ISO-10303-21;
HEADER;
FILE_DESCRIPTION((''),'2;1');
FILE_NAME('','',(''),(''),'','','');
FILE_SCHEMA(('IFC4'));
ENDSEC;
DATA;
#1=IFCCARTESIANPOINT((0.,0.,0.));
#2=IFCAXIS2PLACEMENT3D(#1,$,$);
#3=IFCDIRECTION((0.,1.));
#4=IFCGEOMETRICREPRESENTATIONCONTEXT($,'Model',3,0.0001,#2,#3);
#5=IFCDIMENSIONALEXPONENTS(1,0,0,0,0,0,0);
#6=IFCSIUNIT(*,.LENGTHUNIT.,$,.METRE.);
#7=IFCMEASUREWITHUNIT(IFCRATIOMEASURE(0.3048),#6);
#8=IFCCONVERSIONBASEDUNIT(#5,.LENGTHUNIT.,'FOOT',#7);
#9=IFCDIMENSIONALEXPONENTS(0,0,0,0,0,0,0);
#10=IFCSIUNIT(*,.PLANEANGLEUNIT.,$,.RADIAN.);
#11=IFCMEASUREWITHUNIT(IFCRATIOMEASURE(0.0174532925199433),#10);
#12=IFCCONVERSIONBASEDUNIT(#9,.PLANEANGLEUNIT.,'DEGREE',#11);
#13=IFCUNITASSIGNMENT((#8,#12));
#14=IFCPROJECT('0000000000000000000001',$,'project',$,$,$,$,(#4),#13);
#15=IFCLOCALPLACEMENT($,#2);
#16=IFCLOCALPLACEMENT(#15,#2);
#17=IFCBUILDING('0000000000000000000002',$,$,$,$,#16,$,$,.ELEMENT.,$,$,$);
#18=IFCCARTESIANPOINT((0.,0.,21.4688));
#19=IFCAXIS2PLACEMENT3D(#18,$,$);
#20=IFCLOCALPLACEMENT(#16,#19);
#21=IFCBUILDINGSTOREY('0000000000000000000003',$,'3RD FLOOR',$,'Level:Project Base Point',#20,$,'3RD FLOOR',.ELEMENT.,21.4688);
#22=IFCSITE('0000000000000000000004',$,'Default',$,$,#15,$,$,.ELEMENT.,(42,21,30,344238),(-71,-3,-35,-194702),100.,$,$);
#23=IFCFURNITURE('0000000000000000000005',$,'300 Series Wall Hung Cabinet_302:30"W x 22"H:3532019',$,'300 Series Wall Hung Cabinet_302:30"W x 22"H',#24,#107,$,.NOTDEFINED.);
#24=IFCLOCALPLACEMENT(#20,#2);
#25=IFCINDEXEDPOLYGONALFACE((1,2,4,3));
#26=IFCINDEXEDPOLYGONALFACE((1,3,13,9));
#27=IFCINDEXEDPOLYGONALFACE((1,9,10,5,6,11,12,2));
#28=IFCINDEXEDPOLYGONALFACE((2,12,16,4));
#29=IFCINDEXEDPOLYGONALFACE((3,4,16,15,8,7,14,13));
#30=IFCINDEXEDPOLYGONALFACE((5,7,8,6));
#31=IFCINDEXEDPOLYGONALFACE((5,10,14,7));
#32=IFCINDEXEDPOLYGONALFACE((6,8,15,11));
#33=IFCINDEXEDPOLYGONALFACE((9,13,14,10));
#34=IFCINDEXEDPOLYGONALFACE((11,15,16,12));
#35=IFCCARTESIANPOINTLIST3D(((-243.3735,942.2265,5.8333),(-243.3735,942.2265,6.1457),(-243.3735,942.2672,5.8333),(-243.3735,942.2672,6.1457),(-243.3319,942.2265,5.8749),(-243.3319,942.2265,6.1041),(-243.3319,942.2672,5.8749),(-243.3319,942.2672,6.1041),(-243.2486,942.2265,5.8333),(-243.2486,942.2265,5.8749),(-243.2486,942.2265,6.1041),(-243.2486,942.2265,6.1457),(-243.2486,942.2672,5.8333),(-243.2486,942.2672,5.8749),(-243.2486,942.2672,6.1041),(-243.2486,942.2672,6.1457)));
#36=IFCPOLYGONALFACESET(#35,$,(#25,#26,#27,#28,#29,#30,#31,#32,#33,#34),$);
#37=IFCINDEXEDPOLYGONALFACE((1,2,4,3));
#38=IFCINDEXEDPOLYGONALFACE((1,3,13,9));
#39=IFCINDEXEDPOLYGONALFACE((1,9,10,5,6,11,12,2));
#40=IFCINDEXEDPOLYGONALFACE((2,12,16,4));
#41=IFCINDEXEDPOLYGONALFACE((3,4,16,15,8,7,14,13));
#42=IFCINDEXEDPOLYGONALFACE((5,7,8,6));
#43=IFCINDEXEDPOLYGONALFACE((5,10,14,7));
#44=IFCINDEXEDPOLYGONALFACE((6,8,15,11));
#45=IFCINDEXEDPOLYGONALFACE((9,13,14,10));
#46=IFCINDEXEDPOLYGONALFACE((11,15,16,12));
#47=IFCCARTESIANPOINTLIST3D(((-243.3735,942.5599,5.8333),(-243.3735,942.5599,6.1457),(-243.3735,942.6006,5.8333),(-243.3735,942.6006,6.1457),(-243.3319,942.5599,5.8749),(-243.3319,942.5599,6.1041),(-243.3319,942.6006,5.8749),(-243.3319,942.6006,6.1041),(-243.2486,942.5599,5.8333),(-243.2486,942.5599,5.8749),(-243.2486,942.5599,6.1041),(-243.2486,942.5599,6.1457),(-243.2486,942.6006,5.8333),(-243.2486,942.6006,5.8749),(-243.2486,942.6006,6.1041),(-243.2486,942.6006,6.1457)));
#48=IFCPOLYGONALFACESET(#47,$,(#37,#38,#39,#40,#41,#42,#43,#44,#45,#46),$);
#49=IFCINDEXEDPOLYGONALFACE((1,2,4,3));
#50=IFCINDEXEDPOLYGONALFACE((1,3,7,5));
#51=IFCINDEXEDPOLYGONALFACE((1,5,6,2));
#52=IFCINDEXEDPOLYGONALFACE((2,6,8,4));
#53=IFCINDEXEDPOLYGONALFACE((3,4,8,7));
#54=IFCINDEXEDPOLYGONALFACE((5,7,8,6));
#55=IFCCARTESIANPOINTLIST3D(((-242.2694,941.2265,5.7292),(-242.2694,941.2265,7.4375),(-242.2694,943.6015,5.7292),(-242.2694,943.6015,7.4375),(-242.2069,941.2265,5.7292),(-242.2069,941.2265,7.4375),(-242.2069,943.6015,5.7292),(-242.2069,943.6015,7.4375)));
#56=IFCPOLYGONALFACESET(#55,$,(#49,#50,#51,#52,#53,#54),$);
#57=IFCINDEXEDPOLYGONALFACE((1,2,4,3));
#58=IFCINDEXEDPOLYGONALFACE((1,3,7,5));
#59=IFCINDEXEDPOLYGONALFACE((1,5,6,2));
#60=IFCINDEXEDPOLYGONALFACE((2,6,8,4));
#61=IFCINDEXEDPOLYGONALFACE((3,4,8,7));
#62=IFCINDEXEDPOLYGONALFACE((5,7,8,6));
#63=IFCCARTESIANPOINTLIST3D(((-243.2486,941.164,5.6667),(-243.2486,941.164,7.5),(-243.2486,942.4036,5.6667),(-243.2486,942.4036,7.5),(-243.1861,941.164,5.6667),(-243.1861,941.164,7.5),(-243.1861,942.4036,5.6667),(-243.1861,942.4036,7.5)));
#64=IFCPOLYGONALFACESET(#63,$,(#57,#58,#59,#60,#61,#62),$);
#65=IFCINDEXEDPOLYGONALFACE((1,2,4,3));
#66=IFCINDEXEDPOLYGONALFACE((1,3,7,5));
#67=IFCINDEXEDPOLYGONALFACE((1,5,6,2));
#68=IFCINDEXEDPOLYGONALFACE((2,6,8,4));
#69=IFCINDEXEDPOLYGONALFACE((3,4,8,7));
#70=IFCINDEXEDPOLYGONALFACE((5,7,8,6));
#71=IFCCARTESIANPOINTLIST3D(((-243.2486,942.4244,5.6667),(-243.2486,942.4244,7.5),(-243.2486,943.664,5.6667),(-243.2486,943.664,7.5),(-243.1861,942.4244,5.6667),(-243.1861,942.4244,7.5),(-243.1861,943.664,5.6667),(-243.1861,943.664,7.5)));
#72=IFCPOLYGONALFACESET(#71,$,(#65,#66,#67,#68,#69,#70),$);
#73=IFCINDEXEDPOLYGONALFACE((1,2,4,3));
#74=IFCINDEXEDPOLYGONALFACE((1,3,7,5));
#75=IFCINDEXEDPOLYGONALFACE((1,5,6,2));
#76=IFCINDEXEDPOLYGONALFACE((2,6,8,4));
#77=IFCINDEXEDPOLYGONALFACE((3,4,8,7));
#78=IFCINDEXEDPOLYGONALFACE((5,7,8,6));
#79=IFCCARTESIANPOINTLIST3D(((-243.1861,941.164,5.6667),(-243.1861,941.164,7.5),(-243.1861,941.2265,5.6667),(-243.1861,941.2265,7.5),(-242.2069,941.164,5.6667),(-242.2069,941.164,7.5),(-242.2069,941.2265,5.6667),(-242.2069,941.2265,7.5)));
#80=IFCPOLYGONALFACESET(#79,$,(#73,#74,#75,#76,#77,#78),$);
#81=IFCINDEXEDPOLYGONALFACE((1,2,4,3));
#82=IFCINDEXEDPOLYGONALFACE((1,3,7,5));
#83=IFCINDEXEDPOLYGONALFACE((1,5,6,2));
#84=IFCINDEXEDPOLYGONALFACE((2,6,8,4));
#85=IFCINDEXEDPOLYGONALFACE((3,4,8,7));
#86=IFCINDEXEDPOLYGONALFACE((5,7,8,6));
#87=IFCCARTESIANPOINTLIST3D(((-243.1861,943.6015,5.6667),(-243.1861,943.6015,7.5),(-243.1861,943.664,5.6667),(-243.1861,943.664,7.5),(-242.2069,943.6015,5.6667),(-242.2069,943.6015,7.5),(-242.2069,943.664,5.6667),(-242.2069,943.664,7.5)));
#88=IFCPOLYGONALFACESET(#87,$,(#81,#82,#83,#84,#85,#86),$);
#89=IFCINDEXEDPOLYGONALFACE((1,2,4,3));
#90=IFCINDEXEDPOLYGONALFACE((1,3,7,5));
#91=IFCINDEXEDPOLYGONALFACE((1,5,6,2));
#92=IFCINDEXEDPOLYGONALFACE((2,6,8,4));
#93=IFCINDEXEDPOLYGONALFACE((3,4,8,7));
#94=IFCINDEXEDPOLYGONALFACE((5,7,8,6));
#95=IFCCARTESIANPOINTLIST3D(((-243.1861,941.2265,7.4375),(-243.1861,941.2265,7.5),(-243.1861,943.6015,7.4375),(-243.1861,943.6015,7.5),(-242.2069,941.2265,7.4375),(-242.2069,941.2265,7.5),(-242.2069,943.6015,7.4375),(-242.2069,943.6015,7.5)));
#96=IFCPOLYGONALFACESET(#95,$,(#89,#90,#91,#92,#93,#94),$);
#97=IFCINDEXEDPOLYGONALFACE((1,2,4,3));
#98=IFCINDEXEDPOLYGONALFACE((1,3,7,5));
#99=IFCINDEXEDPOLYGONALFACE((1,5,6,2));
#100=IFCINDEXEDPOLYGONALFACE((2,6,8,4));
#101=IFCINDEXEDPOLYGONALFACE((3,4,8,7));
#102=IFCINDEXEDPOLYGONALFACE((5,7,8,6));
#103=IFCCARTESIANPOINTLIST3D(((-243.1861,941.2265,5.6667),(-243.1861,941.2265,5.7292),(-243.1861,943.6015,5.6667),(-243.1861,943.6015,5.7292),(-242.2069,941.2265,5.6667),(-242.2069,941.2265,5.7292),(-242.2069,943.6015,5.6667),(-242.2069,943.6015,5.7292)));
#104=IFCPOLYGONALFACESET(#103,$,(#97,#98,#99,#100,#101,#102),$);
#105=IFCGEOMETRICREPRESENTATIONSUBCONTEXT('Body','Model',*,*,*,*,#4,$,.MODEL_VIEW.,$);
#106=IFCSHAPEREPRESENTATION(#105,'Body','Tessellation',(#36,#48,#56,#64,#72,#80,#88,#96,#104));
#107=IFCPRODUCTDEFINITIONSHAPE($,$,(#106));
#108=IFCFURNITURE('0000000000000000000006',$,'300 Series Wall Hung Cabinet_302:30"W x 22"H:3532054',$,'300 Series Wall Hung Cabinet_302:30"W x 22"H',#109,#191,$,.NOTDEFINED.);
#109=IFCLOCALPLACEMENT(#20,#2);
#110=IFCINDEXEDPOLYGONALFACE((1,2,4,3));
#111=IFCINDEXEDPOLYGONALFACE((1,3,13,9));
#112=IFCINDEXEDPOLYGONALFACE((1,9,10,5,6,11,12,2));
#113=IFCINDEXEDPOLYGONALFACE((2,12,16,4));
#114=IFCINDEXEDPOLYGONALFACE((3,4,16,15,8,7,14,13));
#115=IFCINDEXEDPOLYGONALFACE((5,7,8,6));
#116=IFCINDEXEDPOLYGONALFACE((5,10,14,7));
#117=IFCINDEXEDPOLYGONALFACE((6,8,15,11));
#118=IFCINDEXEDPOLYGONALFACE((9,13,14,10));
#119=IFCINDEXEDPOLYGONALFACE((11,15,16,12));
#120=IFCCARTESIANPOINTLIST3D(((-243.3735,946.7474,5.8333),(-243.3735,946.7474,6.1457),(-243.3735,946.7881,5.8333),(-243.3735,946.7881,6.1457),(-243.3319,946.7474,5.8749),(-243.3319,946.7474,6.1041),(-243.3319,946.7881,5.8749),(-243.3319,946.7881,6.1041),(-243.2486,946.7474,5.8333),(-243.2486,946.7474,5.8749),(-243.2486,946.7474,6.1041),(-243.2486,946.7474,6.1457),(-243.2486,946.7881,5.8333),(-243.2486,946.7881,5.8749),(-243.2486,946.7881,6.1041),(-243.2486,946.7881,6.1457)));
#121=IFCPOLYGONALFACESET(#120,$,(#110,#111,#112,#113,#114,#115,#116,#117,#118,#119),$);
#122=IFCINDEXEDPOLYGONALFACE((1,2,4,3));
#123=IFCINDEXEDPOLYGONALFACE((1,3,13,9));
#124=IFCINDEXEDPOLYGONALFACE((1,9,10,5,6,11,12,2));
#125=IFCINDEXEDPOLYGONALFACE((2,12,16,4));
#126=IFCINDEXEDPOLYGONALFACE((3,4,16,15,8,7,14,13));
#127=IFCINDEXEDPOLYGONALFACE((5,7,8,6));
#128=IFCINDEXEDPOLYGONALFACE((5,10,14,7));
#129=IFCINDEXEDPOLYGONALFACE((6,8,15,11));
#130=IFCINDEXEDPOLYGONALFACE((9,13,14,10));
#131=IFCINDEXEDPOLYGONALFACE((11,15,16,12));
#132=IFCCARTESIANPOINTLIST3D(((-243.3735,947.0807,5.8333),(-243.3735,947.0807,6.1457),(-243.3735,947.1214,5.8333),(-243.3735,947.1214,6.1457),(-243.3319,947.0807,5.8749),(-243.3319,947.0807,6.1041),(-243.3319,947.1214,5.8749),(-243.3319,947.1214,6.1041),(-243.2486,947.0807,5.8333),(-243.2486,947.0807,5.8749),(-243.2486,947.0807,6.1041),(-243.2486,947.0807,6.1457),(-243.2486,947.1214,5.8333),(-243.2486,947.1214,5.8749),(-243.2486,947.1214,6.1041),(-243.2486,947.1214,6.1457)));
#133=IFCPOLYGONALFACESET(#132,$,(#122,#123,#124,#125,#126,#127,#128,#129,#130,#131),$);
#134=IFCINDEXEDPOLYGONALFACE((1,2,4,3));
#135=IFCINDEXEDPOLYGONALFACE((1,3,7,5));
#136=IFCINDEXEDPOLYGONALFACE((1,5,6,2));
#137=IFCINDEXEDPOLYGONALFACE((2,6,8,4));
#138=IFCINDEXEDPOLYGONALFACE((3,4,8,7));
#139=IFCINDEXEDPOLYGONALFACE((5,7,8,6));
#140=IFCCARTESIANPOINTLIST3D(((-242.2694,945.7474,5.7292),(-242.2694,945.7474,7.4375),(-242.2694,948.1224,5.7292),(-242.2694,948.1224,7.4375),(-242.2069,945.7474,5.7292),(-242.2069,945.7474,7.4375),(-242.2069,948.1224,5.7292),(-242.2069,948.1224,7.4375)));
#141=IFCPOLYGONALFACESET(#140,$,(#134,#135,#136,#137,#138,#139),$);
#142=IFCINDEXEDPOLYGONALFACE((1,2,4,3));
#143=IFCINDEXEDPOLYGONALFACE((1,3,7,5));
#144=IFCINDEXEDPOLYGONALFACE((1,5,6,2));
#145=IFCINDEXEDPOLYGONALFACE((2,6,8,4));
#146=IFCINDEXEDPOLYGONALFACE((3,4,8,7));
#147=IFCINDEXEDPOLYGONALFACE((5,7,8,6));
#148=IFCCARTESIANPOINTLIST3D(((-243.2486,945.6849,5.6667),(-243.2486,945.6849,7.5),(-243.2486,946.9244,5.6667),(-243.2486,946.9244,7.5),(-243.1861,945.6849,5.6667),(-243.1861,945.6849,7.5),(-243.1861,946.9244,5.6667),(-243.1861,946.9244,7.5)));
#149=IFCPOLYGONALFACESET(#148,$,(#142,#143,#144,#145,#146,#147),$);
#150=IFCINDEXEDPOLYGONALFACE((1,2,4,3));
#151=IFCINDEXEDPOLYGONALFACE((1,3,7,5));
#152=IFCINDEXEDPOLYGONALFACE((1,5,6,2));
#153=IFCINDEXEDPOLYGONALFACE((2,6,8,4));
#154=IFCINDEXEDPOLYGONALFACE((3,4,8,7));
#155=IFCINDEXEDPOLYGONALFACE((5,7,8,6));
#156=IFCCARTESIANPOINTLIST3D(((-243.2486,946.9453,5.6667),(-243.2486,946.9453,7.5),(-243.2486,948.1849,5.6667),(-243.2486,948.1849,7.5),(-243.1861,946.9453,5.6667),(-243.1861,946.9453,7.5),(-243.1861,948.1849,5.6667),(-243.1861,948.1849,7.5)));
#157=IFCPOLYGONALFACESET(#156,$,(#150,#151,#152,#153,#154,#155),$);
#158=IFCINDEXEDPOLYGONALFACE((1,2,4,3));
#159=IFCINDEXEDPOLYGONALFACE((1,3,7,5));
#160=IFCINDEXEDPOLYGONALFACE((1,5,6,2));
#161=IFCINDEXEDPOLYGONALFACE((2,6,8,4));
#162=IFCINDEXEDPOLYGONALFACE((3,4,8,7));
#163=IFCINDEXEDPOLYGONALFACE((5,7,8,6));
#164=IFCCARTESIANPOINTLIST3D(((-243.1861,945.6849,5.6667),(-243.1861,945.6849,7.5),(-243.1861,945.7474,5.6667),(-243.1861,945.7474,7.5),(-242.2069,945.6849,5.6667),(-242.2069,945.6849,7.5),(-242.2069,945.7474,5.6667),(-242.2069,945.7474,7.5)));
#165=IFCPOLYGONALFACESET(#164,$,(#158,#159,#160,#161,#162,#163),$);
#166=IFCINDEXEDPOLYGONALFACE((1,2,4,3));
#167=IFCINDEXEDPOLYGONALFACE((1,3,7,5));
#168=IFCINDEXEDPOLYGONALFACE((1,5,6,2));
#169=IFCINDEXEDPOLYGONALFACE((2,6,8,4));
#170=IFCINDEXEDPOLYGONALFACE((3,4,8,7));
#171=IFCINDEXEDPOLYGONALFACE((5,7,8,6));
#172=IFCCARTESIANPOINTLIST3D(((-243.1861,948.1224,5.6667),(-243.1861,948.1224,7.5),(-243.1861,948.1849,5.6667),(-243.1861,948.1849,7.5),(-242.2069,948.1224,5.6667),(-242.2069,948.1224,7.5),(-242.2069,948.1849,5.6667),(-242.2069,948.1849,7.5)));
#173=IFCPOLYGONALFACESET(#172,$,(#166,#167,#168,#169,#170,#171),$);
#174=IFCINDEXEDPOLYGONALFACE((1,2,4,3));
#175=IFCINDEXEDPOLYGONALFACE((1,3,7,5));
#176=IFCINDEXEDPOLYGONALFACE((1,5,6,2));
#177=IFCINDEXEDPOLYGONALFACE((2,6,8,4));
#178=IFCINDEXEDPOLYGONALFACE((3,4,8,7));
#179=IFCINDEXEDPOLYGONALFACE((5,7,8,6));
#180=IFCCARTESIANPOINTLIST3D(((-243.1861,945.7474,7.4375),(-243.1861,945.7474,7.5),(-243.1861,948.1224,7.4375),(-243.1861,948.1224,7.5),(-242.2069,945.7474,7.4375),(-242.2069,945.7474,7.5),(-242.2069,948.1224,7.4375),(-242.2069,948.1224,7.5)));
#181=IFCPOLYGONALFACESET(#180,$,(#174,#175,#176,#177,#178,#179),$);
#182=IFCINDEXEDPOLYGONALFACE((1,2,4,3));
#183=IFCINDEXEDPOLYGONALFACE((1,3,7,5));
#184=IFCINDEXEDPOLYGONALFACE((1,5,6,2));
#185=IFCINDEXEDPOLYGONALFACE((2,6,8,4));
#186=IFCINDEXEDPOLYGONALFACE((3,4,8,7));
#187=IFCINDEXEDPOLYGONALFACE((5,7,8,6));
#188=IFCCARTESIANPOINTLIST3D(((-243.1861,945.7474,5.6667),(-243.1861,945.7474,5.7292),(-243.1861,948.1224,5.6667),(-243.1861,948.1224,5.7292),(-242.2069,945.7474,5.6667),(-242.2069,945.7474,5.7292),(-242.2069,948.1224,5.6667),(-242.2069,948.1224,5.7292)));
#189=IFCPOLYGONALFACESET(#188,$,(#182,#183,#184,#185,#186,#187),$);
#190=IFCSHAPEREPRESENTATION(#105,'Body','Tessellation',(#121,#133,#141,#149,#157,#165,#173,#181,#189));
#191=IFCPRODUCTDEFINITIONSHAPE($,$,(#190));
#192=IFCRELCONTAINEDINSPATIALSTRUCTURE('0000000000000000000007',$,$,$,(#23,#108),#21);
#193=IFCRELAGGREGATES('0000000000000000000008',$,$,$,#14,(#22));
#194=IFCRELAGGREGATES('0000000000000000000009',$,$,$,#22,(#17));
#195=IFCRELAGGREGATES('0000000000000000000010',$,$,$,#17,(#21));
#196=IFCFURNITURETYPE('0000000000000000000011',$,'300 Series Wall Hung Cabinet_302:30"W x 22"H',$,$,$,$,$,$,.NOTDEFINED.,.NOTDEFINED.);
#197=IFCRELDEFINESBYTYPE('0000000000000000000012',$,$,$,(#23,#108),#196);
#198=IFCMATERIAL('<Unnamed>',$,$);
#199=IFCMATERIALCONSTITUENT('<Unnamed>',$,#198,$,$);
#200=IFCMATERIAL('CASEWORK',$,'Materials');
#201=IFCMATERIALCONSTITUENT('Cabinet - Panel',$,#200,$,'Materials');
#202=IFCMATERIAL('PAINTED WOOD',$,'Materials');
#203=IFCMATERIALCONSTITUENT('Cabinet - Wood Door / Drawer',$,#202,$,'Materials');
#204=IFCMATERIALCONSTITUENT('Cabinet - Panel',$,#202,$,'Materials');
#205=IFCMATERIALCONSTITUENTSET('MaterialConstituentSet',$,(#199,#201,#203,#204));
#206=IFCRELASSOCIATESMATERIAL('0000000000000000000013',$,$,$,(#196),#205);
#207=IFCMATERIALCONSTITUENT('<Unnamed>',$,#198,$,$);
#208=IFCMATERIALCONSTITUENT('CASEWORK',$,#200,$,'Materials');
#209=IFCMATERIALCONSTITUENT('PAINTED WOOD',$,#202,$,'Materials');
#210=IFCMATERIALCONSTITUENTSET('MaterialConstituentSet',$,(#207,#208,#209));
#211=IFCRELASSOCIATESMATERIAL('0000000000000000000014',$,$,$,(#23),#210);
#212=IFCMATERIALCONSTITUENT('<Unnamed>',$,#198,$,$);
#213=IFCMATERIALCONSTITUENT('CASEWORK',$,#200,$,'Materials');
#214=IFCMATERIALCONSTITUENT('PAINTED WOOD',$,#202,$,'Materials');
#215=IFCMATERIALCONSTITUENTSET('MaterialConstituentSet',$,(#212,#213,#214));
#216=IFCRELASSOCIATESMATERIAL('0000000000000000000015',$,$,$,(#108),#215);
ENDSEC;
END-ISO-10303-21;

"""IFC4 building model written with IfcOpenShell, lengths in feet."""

from ifc_helpers import new_model, entity, si_unit, converted_unit, direction, frame, frame_2d, origin, origin_2d_with_axis, place, context, subcontext, project, spatial, polyline, rectangle, outline, extrude, source, transform, mapped, material, constituent, constituent_set, type_object, type_shapes, element, save


model = new_model("IFC4")

# Units and contexts
model_context = context("Model", 3, precision=0.0001, world=origin(), true_north=direction((0.0, 1.0)))
body_context = subcontext(model_context, "Body", "Model", "MODEL_VIEW")
ifc_project = project(units=[converted_unit("LENGTHUNIT", "FOOT", entity("IfcRatioMeasure", 0.3048), si_unit("LENGTHUNIT", "METRE"), dimensions=[1, 0, 0, 0, 0, 0, 0]), converted_unit("PLANEANGLEUNIT", "DEGREE", entity("IfcRatioMeasure", 0.0174532925199433), si_unit("PLANEANGLEUNIT", "RADIAN"), dimensions=[0, 0, 0, 0, 0, 0, 0])], contexts=[model_context])

# Site, building, storey
site_placement = place(None, origin())
site = spatial("IfcSite", under=ifc_project, at=site_placement, Name="Default", CompositionType="ELEMENT", RefLatitude=(42, 21, 30, 344238), RefLongitude=(-71, -3, -35, -194702), RefElevation=100.0)
building_placement = place(site_placement, origin())
building = spatial("IfcBuilding", under=site, at=building_placement, CompositionType="ELEMENT")
storey_placement = place(building_placement, frame((0.0, 0.0, 21.4688)))
storey = spatial("IfcBuildingStorey", under=building, at=storey_placement, Name="3RD FLOOR", ObjectType="Level:Project Base Point", LongName="3RD FLOOR", CompositionType="ELEMENT", Elevation=21.4688)

# Furniture
ifc_material_1 = material(Name="CASEWORK", Category="Materials")
ifc_material_2 = material(Name="<Unnamed>")
ifc_constituent_1 = constituent(ifc_material_2, Name="<Unnamed>")
ifc_constituent_2 = constituent(ifc_material_1, Name="CASEWORK", Category="Materials")
ifc_material_3 = material(Name="PAINTED WOOD", Category="Materials")
ifc_constituent_3 = constituent(ifc_material_3, Name="PAINTED WOOD", Category="Materials")
ifc_constituent_set_1 = constituent_set(constituents=[ifc_constituent_1, ifc_constituent_2, ifc_constituent_3], Name="MaterialConstituentSet")
ifc_constituent_4 = constituent(ifc_material_2, Name="<Unnamed>")
ifc_constituent_5 = constituent(ifc_material_1, Name="Cabinet - Panel", Category="Materials")
ifc_constituent_6 = constituent(ifc_material_3, Name="Cabinet - Wood Door / Drawer", Category="Materials")
ifc_constituent_7 = constituent(ifc_material_3, Name="Cabinet - Panel", Category="Materials")
ifc_constituent_set_2 = constituent_set(constituents=[ifc_constituent_4, ifc_constituent_5, ifc_constituent_6, ifc_constituent_7], Name="MaterialConstituentSet")
furniture_type_1 = type_object("IfcFurnitureType", Name="300 Series Wall Hung Cabinet_302:30\"W x 22\"H", AssemblyPlace="NOTDEFINED", PredefinedType="NOTDEFINED", material=ifc_constituent_set_2)
shared_shape_1 = source(origin(), body_context, "Body", "SweptSolid", [
    extrude(outline(polyline([(-0.0521, -0.1146), (-0.0521, -0.1562), (0.0729, -0.1562), (0.0729, 0.1562), (-0.0521, 0.1562), (-0.0521, 0.1146), (0.0313, 0.1146), (0.0313, -0.1146), (-0.0521, -0.1146)])), frame((1.0625, 1.0937, 0.3229), z_axis=(-1.0, 0.0, 0.0), x_axis=(0.0, 1.0, 0.0)), (0.0, 0.0, -1.0), 0.0407),
    extrude(outline(polyline([(-0.0521, -0.1146), (-0.0521, -0.1562), (0.0729, -0.1562), (0.0729, 0.1562), (-0.0521, 0.1562), (-0.0521, 0.1146), (0.0313, 0.1146), (0.0313, -0.1146), (-0.0521, -0.1146)])), frame((1.3958, 1.0937, 0.3229), z_axis=(-1.0, 0.0, 0.0), x_axis=(0.0, 1.0, 0.0)), (0.0, 0.0, -1.0), 0.0407),
    extrude(rectangle(XDim=0.0625, YDim=2.375, at=frame_2d((0.0, 0.0), x_axis=(1.0, 0.0))), frame((1.25, 0.0313, 0.0625), z_axis=(0.0, 0.0, 1.0), x_axis=(0.0, 1.0, 0.0)), (0.0, 0.0, 1.0), 1.7083),
    extrude(rectangle(XDim=0.0625, YDim=1.2396, at=origin_2d_with_axis()), frame((0.6198, 1.0104, 0.0), z_axis=(0.0, 0.0, 1.0), x_axis=(0.0, 1.0, 0.0)), (0.0, 0.0, 1.0), 1.8333),
    extrude(rectangle(XDim=0.0625, YDim=1.2396, at=frame_2d((0.0, 0.0), x_axis=(1.0, 0.0))), frame((1.8802, 1.0104, 0.0), z_axis=(0.0, 0.0, 1.0), x_axis=(0.0, 1.0, 0.0)), (0.0, 0.0, 1.0), 1.8333),
    extrude(rectangle(XDim=0.0625, YDim=0.9792, at=frame_2d((0.0, 0.0), x_axis=(1.0, 0.0))), frame((0.0313, 0.4896, 0.0)), (0.0, 0.0, 1.0), 1.8333),
    extrude(rectangle(XDim=0.0625, YDim=0.9792, at=frame_2d((0.0, 0.0), x_axis=(1.0, 0.0))), frame((2.4688, 0.4896, 0.0)), (0.0, 0.0, 1.0), 1.8333),
    extrude(rectangle(XDim=2.375, YDim=0.9792, at=frame_2d((0.0, 0.0), x_axis=(1.0, 0.0))), frame((1.25, 0.4896, 1.7708), z_axis=(0.0, 0.0, 1.0), x_axis=(-1.0, 0.0, 0.0)), (0.0, 0.0, 1.0), 0.0625),
    extrude(rectangle(XDim=2.375, YDim=0.9792, at=frame_2d((0.0, 0.0), x_axis=(1.0, 0.0))), frame((1.25, 0.4896, 0.0), z_axis=(0.0, 0.0, 1.0), x_axis=(-1.0, 0.0, 0.0)), (0.0, 0.0, 1.0), 0.0625),
])
type_shapes(furniture_type_1, [shared_shape_1])
furniture_1_placement = place(storey_placement, frame((-242.2069, 941.164, 5.6667), z_axis=(0.0, 0.0, 1.0), x_axis=(0.0, 1.0, 0.0)))
element("IfcFurniture", 1, at=furniture_1_placement, inside=storey, type_object=furniture_type_1, material=ifc_constituent_set_1, Name="300 Series Wall Hung Cabinet_302:30\"W x 22\"H:3532019", ObjectType="300 Series Wall Hung Cabinet_302:30\"W x 22\"H", PredefinedType="NOTDEFINED", context=body_context, shape_type="MappedRepresentation", body=[
    mapped(shared_shape_1, transform((0.0, 0.0, 0.0), scale=1.0)),
])
ifc_constituent_8 = constituent(ifc_material_2, Name="<Unnamed>")
ifc_constituent_9 = constituent(ifc_material_1, Name="CASEWORK", Category="Materials")
ifc_constituent_10 = constituent(ifc_material_3, Name="PAINTED WOOD", Category="Materials")
ifc_constituent_set_3 = constituent_set(constituents=[ifc_constituent_8, ifc_constituent_9, ifc_constituent_10], Name="MaterialConstituentSet")
furniture_2_placement = place(storey_placement, frame((-242.2069, 945.6849, 5.6667), z_axis=(0.0, 0.0, 1.0), x_axis=(0.0, 1.0, 0.0)))
element("IfcFurniture", 2, at=furniture_2_placement, inside=storey, type_object=furniture_type_1, material=ifc_constituent_set_3, Name="300 Series Wall Hung Cabinet_302:30\"W x 22\"H:3532054", ObjectType="300 Series Wall Hung Cabinet_302:30\"W x 22\"H", PredefinedType="NOTDEFINED", context=body_context, shape_type="MappedRepresentation", body=[
    mapped(shared_shape_1, transform((0.0, 0.0, 0.0), scale=1.0)),
])

save(model, "model.ifc")
